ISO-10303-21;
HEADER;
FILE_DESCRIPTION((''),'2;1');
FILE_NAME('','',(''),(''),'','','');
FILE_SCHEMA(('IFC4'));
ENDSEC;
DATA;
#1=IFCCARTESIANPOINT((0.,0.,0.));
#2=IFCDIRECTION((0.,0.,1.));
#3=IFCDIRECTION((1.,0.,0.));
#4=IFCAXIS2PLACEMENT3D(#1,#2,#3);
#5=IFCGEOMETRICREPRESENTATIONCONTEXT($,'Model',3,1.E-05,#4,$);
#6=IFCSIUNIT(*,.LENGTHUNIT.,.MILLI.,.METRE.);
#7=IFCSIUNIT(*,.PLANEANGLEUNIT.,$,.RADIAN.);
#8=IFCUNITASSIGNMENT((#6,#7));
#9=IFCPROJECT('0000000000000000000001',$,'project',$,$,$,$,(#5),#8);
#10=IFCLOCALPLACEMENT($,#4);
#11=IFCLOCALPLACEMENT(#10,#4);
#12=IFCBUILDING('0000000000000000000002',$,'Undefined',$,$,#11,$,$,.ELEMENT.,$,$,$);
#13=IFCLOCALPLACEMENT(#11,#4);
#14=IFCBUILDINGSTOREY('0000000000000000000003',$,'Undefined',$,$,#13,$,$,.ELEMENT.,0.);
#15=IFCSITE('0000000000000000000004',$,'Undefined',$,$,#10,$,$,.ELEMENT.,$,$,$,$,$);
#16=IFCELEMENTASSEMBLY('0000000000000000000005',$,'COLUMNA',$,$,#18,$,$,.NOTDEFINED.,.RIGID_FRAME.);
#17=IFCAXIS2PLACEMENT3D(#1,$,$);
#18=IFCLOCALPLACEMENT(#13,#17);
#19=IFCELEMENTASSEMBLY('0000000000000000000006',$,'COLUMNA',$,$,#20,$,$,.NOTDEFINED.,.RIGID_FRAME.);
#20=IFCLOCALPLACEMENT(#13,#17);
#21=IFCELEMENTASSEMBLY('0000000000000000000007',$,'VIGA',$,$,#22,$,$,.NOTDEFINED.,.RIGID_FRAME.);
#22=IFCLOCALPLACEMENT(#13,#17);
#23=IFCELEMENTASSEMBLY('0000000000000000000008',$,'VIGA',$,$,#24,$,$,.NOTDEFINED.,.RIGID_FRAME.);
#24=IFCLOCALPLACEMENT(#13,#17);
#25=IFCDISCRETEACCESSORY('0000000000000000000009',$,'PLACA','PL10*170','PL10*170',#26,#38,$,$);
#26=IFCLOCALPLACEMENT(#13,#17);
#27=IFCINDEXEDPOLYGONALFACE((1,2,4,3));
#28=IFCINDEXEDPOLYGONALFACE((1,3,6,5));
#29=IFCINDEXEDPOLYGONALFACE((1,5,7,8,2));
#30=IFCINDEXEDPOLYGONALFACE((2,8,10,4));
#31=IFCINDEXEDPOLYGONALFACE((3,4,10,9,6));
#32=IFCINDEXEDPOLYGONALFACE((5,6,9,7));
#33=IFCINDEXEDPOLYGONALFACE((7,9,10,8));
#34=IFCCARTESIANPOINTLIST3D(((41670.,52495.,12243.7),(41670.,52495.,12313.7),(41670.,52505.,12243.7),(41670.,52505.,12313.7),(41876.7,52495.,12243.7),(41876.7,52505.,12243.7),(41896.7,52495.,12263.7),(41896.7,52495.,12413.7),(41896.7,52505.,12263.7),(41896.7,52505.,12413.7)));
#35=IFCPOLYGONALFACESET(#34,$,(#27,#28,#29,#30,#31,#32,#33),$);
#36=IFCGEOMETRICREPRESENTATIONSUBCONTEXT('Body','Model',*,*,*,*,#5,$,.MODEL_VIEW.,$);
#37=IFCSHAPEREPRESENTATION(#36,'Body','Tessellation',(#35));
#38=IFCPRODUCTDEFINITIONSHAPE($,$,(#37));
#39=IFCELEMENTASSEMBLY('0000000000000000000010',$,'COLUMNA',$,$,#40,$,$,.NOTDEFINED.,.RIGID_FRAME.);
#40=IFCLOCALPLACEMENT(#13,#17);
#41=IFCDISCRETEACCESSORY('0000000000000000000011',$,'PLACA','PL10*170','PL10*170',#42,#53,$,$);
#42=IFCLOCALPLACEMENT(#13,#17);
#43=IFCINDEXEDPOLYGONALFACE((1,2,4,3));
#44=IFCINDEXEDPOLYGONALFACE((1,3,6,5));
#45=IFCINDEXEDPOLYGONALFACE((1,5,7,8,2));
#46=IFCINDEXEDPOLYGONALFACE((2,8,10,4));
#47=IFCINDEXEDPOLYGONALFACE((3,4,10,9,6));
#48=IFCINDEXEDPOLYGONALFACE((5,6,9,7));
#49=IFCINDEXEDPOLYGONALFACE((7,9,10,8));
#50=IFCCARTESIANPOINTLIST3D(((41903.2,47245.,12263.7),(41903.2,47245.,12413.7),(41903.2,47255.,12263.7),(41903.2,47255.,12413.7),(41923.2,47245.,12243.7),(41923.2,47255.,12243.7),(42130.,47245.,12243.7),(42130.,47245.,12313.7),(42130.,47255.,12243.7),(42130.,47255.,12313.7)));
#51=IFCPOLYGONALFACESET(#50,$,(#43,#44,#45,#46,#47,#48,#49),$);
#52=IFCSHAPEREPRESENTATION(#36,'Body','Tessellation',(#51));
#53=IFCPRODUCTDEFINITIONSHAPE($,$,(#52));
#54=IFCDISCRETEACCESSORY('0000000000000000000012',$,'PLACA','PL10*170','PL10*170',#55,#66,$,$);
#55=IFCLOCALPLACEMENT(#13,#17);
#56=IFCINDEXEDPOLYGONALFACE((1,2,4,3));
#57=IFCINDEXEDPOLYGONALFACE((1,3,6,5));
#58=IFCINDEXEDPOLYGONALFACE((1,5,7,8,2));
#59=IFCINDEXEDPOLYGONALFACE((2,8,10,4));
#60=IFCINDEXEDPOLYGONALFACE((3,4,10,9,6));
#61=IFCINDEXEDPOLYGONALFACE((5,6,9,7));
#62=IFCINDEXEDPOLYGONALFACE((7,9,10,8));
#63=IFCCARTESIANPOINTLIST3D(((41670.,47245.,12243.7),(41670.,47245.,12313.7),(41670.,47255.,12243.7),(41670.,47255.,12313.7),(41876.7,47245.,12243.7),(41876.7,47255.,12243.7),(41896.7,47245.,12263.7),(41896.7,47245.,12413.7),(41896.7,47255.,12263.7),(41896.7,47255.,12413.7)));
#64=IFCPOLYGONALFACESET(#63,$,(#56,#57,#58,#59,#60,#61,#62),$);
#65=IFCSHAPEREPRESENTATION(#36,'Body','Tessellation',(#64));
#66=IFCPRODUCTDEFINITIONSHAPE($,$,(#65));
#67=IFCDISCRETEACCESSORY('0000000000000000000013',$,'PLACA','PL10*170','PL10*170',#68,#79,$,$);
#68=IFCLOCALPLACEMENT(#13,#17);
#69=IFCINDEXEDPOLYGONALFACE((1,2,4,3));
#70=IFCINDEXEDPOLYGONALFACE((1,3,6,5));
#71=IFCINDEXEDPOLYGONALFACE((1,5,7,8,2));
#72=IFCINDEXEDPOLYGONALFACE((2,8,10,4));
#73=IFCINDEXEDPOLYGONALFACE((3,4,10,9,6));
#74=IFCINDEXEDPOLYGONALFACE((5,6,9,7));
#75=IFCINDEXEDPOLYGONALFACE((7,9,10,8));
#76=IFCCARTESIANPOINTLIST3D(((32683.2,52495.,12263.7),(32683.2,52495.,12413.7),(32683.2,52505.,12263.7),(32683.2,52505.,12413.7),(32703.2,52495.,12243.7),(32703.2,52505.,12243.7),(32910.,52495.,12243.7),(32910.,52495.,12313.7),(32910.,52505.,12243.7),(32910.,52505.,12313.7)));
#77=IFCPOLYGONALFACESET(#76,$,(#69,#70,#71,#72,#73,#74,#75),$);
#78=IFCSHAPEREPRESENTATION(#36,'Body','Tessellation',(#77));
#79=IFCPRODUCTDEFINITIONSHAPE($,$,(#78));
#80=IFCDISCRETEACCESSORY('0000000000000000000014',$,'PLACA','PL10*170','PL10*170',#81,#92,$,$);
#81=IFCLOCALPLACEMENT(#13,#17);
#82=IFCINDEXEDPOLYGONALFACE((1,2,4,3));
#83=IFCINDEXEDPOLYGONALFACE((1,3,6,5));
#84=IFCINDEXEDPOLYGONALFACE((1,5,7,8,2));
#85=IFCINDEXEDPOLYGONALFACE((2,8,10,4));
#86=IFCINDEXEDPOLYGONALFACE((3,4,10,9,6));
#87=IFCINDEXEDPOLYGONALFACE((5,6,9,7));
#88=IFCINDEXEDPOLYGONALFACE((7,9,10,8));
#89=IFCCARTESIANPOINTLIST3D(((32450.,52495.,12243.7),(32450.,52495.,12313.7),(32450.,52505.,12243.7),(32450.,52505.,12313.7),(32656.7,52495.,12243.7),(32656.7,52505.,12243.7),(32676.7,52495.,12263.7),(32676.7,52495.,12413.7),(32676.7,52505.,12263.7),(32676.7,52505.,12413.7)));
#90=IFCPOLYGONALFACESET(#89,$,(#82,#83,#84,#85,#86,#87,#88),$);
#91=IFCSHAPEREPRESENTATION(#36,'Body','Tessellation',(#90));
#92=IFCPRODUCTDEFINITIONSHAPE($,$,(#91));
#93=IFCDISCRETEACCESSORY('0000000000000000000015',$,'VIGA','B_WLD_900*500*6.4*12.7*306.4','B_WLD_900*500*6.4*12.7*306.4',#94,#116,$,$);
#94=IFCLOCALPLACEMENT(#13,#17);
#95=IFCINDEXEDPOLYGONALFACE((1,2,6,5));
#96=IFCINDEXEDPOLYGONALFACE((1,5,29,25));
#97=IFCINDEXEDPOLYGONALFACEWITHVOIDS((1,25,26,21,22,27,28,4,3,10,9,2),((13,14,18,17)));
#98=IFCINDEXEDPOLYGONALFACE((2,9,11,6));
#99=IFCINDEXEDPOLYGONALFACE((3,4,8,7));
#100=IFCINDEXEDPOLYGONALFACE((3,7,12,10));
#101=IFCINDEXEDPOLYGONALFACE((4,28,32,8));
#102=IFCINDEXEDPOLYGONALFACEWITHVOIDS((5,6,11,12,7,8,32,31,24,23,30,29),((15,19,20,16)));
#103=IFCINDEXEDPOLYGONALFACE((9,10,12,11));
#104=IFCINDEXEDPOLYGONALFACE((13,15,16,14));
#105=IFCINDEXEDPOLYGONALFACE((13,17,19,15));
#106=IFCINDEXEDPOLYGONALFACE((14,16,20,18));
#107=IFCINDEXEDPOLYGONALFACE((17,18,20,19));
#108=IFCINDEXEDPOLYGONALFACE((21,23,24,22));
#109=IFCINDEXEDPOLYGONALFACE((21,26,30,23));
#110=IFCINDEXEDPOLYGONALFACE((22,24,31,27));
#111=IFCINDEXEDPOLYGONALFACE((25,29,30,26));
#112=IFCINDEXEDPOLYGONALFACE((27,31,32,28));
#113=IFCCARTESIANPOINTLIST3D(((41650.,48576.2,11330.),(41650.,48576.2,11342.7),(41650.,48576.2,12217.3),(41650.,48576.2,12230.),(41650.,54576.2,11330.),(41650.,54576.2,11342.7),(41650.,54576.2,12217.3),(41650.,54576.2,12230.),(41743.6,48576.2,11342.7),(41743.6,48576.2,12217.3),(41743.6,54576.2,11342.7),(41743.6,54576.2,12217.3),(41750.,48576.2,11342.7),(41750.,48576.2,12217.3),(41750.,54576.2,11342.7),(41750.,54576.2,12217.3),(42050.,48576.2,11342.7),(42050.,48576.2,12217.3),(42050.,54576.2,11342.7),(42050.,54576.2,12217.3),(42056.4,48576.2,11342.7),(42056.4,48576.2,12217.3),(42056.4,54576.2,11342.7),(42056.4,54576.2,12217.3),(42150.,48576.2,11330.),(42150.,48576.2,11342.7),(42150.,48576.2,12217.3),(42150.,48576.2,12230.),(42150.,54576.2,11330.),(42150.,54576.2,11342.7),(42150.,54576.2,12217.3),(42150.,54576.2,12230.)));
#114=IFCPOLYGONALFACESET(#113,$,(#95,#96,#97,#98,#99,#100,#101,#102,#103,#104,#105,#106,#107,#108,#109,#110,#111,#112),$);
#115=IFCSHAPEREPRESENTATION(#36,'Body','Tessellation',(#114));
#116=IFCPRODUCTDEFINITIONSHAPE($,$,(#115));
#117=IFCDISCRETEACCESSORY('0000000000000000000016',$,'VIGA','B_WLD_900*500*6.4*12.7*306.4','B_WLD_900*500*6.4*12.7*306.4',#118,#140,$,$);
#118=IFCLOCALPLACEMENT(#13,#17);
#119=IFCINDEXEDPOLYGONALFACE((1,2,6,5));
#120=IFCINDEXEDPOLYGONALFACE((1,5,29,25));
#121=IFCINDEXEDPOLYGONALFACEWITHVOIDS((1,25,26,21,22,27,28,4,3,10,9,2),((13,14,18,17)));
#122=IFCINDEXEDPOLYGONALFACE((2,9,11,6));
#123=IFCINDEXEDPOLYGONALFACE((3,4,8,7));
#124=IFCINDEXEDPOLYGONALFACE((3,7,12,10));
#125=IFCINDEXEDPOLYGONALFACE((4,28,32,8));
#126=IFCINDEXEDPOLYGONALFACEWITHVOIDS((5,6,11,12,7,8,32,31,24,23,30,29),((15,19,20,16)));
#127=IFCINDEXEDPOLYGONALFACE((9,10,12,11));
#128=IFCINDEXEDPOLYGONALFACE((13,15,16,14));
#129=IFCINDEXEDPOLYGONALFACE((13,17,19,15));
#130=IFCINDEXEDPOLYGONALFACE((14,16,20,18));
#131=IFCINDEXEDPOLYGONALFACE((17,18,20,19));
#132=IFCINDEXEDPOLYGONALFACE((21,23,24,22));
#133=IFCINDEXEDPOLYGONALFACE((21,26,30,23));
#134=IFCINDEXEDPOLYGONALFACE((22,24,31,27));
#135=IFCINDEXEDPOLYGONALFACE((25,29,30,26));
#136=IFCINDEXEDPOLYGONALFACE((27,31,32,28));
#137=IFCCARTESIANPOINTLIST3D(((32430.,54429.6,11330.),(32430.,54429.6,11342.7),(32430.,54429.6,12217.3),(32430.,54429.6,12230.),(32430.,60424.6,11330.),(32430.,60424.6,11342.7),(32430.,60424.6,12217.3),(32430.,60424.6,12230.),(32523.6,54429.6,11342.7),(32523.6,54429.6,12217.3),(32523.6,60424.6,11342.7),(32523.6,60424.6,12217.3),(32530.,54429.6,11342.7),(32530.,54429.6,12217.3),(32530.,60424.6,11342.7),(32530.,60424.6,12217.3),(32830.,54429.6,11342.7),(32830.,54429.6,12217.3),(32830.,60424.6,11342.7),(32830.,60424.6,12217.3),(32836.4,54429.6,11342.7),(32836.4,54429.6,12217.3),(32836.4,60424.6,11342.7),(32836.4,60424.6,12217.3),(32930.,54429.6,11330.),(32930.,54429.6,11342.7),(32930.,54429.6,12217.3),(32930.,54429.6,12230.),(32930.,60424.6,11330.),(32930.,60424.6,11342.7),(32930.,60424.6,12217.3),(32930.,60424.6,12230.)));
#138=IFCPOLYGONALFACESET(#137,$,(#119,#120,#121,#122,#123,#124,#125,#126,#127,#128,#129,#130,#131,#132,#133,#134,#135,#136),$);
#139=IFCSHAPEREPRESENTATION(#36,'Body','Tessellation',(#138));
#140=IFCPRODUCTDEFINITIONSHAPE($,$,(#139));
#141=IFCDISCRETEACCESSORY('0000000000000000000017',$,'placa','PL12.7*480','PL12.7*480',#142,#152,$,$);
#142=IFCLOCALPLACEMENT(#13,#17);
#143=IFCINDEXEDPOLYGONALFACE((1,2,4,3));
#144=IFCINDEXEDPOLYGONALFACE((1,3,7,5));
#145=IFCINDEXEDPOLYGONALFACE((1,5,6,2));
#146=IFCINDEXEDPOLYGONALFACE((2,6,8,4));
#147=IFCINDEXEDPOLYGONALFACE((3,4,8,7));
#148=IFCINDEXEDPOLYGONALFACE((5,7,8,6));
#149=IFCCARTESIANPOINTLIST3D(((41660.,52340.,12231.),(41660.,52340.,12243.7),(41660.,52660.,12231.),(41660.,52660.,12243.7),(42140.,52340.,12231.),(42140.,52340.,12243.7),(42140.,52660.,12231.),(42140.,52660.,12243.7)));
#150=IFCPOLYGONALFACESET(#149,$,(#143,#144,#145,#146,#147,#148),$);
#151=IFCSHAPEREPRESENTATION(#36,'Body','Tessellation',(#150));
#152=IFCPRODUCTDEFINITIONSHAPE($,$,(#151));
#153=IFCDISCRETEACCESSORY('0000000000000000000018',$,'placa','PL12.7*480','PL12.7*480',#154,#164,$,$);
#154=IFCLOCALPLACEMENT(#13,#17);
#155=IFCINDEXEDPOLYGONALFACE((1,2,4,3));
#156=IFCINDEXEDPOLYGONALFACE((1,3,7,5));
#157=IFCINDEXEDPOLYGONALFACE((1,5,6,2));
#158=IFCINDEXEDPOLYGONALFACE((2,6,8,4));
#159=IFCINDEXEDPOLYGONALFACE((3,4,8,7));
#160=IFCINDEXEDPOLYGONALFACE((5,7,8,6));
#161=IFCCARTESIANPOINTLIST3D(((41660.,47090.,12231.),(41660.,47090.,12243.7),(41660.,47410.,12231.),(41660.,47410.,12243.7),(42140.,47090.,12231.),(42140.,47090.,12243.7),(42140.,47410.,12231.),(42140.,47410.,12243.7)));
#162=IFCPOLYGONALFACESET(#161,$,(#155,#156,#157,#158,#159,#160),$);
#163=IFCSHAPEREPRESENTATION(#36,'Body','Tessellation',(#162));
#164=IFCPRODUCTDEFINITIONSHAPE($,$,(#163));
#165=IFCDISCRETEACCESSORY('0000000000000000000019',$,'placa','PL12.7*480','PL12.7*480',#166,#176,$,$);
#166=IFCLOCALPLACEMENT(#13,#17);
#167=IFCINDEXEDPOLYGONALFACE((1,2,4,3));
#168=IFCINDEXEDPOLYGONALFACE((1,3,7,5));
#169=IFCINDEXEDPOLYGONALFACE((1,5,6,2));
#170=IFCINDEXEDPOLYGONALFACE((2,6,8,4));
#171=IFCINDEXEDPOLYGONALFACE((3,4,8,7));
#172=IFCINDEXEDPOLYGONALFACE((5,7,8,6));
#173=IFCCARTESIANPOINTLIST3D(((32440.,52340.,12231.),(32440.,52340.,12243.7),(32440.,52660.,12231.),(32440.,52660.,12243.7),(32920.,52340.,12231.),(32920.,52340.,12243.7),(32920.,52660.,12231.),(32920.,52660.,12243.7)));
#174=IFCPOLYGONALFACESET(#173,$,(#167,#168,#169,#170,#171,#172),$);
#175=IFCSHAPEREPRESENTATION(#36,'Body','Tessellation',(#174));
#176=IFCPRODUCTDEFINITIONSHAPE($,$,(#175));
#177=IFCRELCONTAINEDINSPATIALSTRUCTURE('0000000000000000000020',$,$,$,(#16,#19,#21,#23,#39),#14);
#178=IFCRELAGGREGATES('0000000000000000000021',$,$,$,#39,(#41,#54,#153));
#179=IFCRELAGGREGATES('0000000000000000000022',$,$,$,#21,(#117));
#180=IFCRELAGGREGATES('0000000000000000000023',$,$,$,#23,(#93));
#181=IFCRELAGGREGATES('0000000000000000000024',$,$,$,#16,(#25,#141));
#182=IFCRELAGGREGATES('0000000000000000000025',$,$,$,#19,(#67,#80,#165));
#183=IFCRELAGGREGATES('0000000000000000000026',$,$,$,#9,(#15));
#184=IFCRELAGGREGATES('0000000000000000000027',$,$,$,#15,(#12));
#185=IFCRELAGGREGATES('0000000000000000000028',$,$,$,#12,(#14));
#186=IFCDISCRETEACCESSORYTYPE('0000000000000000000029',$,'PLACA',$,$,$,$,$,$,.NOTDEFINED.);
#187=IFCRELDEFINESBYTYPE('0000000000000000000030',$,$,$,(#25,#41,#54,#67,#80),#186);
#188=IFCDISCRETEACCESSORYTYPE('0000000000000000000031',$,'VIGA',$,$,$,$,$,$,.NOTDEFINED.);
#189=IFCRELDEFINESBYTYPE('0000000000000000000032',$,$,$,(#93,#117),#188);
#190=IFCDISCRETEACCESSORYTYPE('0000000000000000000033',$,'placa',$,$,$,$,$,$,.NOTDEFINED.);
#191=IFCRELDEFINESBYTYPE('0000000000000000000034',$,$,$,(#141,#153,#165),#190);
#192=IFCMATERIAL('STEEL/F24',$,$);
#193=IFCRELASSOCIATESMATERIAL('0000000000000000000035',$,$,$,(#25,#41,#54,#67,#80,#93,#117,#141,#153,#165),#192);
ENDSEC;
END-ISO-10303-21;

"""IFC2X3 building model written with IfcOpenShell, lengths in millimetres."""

from ifc_helpers import new_model, si_unit, frame, origin_with_axes, place, context, subcontext, project, spatial, polyline, outline, extrude, clip, halfspace, material, type_object, element, aggregate, save


model = new_model("IFC2X3")

# Units and contexts
model_context = context("Model", 3, precision=1e-05, world=origin_with_axes())
body_context = subcontext(model_context, "Body", "Model", "MODEL_VIEW")
ifc_project = project(units=[si_unit("LENGTHUNIT", "METRE", prefix="MILLI"), si_unit("PLANEANGLEUNIT", "RADIAN")], contexts=[model_context])

# Site, building, storey
site_placement = place(None, origin_with_axes())
site = spatial("IfcSite", under=ifc_project, at=site_placement, Name="Undefined", CompositionType="ELEMENT")
building_placement = place(site_placement, origin_with_axes())
building = spatial("IfcBuilding", under=site, at=building_placement, Name="Undefined", CompositionType="ELEMENT")
storey_placement = place(building_placement, origin_with_axes())
storey = spatial("IfcBuildingStorey", under=building, at=storey_placement, Name="Undefined", CompositionType="ELEMENT", Elevation=0.0)

# Element assemblies
assembly_1_placement = place(storey_placement, origin_with_axes())
assembly_1 = element("IfcElementAssembly", 1, at=assembly_1_placement, inside=storey, Name="COLUMNA", AssemblyPlace="NOTDEFINED", PredefinedType="RIGID_FRAME")
ifc_material_1 = material(Name="STEEL/F24")
assembly_2_placement = place(storey_placement, origin_with_axes())
assembly_2 = element("IfcElementAssembly", 2, at=assembly_2_placement, inside=storey, Name="COLUMNA", AssemblyPlace="NOTDEFINED", PredefinedType="RIGID_FRAME")

# Element assemblies
assembly_3_placement = place(storey_placement, origin_with_axes())
assembly_3 = element("IfcElementAssembly", 3, at=assembly_3_placement, inside=storey, Name="VIGA", AssemblyPlace="NOTDEFINED", PredefinedType="RIGID_FRAME")
assembly_4_placement = place(storey_placement, origin_with_axes())
assembly_4 = element("IfcElementAssembly", 4, at=assembly_4_placement, inside=storey, Name="VIGA", AssemblyPlace="NOTDEFINED", PredefinedType="RIGID_FRAME")

# Discrete accessory
discrete_accessory_type_1 = type_object("IfcDiscreteAccessoryType", Name="PLACA")
discrete_accessory_1_placement = place(assembly_1_placement, frame((41896.7, 52500.0, 12243.7), z_axis=(0.0, -1.0, 0.0), x_axis=(0.0, 0.0, 1.0)))
discrete_accessory_1 = element("IfcDiscreteAccessory", 5, at=discrete_accessory_1_placement, type_object=discrete_accessory_type_1, material=ifc_material_1, Name="PLACA", Description="PL10*170", ObjectType="PL10*170", context=body_context, shape_type="SweptSolid", body=[
    extrude(outline(polyline([(0.0, 20.0), (20.0, 0.0), (170.0, 0.0), (70.0, 226.7), (0.0, 226.7), (0.0, 20.0)])), frame((0.0, 0.0, -5.0), z_axis=(0.0, 0.0, 1.0), x_axis=(1.0, 0.0, 0.0)), (0.0, 0.0, 1.0), 10.0),
])

# Element assembly, discrete accessories
assembly_5_placement = place(storey_placement, origin_with_axes())
assembly_5 = element("IfcElementAssembly", 6, at=assembly_5_placement, inside=storey, Name="COLUMNA", AssemblyPlace="NOTDEFINED", PredefinedType="RIGID_FRAME")
discrete_accessory_2_placement = place(assembly_5_placement, frame((41903.2, 47250.0, 12243.7), z_axis=(0.0, 1.0, 0.0), x_axis=(0.0, 0.0, 1.0)))
discrete_accessory_2 = element("IfcDiscreteAccessory", 7, at=discrete_accessory_2_placement, type_object=discrete_accessory_type_1, material=ifc_material_1, Name="PLACA", Description="PL10*170", ObjectType="PL10*170", context=body_context, shape_type="SweptSolid", body=[
    extrude(outline(polyline([(0.0, 20.0), (20.0, 0.0), (170.0, 0.0), (70.0, 226.7), (0.0, 226.7), (0.0, 20.0)])), frame((0.0, 0.0, -5.0), z_axis=(0.0, 0.0, 1.0), x_axis=(1.0, 0.0, 0.0)), (0.0, 0.0, 1.0), 10.0),
])
discrete_accessory_3_placement = place(assembly_5_placement, frame((41896.7, 47250.0, 12243.7), z_axis=(0.0, -1.0, 0.0), x_axis=(0.0, 0.0, 1.0)))
discrete_accessory_3 = element("IfcDiscreteAccessory", 8, at=discrete_accessory_3_placement, type_object=discrete_accessory_type_1, material=ifc_material_1, Name="PLACA", Description="PL10*170", ObjectType="PL10*170", context=body_context, shape_type="SweptSolid", body=[
    extrude(outline(polyline([(0.0, 20.0), (20.0, 0.0), (170.0, 0.0), (70.0, 226.7), (0.0, 226.7), (0.0, 20.0)])), frame((0.0, 0.0, -5.0), z_axis=(0.0, 0.0, 1.0), x_axis=(1.0, 0.0, 0.0)), (0.0, 0.0, 1.0), 10.0),
])

# Discrete accessories
discrete_accessory_4_placement = place(assembly_2_placement, frame((32683.2, 52500.0, 12243.7), z_axis=(0.0, 1.0, 0.0), x_axis=(0.0, 0.0, 1.0)))
discrete_accessory_4 = element("IfcDiscreteAccessory", 9, at=discrete_accessory_4_placement, type_object=discrete_accessory_type_1, material=ifc_material_1, Name="PLACA", Description="PL10*170", ObjectType="PL10*170", context=body_context, shape_type="SweptSolid", body=[
    extrude(outline(polyline([(0.0, 20.0), (20.0, 0.0), (170.0, 0.0), (70.0, 226.7), (0.0, 226.7), (0.0, 20.0)])), frame((0.0, 0.0, -5.0), z_axis=(0.0, 0.0, 1.0), x_axis=(1.0, 0.0, 0.0)), (0.0, 0.0, 1.0), 10.0),
])
discrete_accessory_5_placement = place(assembly_2_placement, frame((32676.7, 52500.0, 12243.7), z_axis=(0.0, -1.0, 0.0), x_axis=(0.0, 0.0, 1.0)))
discrete_accessory_5 = element("IfcDiscreteAccessory", 10, at=discrete_accessory_5_placement, type_object=discrete_accessory_type_1, material=ifc_material_1, Name="PLACA", Description="PL10*170", ObjectType="PL10*170", context=body_context, shape_type="SweptSolid", body=[
    extrude(outline(polyline([(0.0, 20.0), (20.0, 0.0), (170.0, 0.0), (70.0, 226.7), (0.0, 226.7), (0.0, 20.0)])), frame((0.0, 0.0, -5.0), z_axis=(0.0, 0.0, 1.0), x_axis=(1.0, 0.0, 0.0)), (0.0, 0.0, 1.0), 10.0),
])
discrete_accessory_type_2 = type_object("IfcDiscreteAccessoryType", Name="VIGA")
discrete_accessory_6_placement = place(assembly_4_placement, frame((41900.0, 48576.2, 11780.0), z_axis=(0.0, 0.0, 1.0), x_axis=(0.0, 1.0, 0.0)))
discrete_accessory_6 = element("IfcDiscreteAccessory", 11, at=discrete_accessory_6_placement, type_object=discrete_accessory_type_2, material=ifc_material_1, Name="VIGA", Description="B_WLD_900*500*6.4*12.7*306.4", ObjectType="B_WLD_900*500*6.4*12.7*306.4", context=body_context, shape_type="SweptSolid", body=[
    extrude(outline(polyline([(-250.0, 437.3), (-250.0, 450.0), (250.0, 450.0), (250.0, 437.3), (156.4, 437.3), (156.4, -437.3), (250.0, -437.3), (250.0, -450.0), (-250.0, -450.0), (-250.0, -437.3), (-156.4, -437.3), (-156.4, 437.3), (-250.0, 437.3)]), holes=[polyline([(-150.0, -437.3), (150.0, -437.3), (150.0, 437.3), (-150.0, 437.3), (-150.0, -437.3)])]), frame((6000.0, 0.0, 0.0), z_axis=(-1.0, 0.0, 0.0), x_axis=(0.0, -1.0, 0.0)), (0.0, 0.0, 1.0), 6000.0),
])
discrete_accessory_7_placement = place(assembly_3_placement, frame((32680.0, 54424.6, 11780.0), z_axis=(0.0, 0.0, 1.0), x_axis=(0.0, 1.0, 0.0)))
discrete_accessory_7 = element("IfcDiscreteAccessory", 12, at=discrete_accessory_7_placement, type_object=discrete_accessory_type_2, material=ifc_material_1, Name="VIGA", Description="B_WLD_900*500*6.4*12.7*306.4", ObjectType="B_WLD_900*500*6.4*12.7*306.4", context=body_context, shape_type="Clipping", body=[
    clip(extrude(outline(polyline([(-250.0, 437.3), (-250.0, 450.0), (250.0, 450.0), (250.0, 437.3), (156.4, 437.3), (156.4, -437.3), (250.0, -437.3), (250.0, -450.0), (-250.0, -450.0), (-250.0, -437.3), (-156.4, -437.3), (-156.4, 437.3), (-250.0, 437.3)]), holes=[polyline([(-150.0, -437.3), (150.0, -437.3), (150.0, 437.3), (-150.0, 437.3), (-150.0, -437.3)])]), frame((6000.0, 0.0, 0.0), z_axis=(-1.0, 0.0, 0.0), x_axis=(0.0, -1.0, 0.0)), (0.0, 0.0, 1.0), 6000.0), halfspace(frame((5.0, -175.0, 450.0), z_axis=(-1.0, -0.000001, 0.0), x_axis=(0.0, 0.0, -1.0)), False)),
])
discrete_accessory_type_3 = type_object("IfcDiscreteAccessoryType", Name="placa")
discrete_accessory_8_placement = place(assembly_1_placement, frame((41900.0, 52660.0, 12237.4), z_axis=(0.0, 0.0, 1.0), x_axis=(0.0, -1.0, 0.0)))
discrete_accessory_8 = element("IfcDiscreteAccessory", 13, at=discrete_accessory_8_placement, type_object=discrete_accessory_type_3, material=ifc_material_1, Name="placa", Description="PL12.7*480", ObjectType="PL12.7*480", context=body_context, shape_type="SweptSolid", body=[
    extrude(outline(polyline([(320.0, -240.0), (0.0, -240.0), (0.0, 240.0), (320.0, 240.0), (320.0, -240.0)])), frame((0.0, 0.0, -6.3), z_axis=(0.0, 0.0, 1.0), x_axis=(1.0, 0.0, 0.0)), (0.0, 0.0, 1.0), 12.7),
])
discrete_accessory_9_placement = place(assembly_5_placement, frame((41900.0, 47410.0, 12237.4), z_axis=(0.0, 0.0, 1.0), x_axis=(0.0, -1.0, 0.0)))
discrete_accessory_9 = element("IfcDiscreteAccessory", 14, at=discrete_accessory_9_placement, type_object=discrete_accessory_type_3, material=ifc_material_1, Name="placa", Description="PL12.7*480", ObjectType="PL12.7*480", context=body_context, shape_type="SweptSolid", body=[
    extrude(outline(polyline([(320.0, -240.0), (0.0, -240.0), (0.0, 240.0), (320.0, 240.0), (320.0, -240.0)])), frame((0.0, 0.0, -6.3), z_axis=(0.0, 0.0, 1.0), x_axis=(1.0, 0.0, 0.0)), (0.0, 0.0, 1.0), 12.7),
])
aggregate(assembly_5, [discrete_accessory_2, discrete_accessory_3, discrete_accessory_9])
discrete_accessory_10_placement = place(assembly_2_placement, frame((32680.0, 52660.0, 12237.4), z_axis=(0.0, 0.0, 1.0), x_axis=(0.0, -1.0, 0.0)))
discrete_accessory_10 = element("IfcDiscreteAccessory", 15, at=discrete_accessory_10_placement, type_object=discrete_accessory_type_3, material=ifc_material_1, Name="placa", Description="PL12.7*480", ObjectType="PL12.7*480", context=body_context, shape_type="SweptSolid", body=[
    extrude(outline(polyline([(320.0, -240.0), (0.0, -240.0), (0.0, 240.0), (320.0, 240.0), (320.0, -240.0)])), frame((0.0, 0.0, -6.3), z_axis=(0.0, 0.0, 1.0), x_axis=(1.0, 0.0, 0.0)), (0.0, 0.0, 1.0), 12.7),
])

aggregate(assembly_3, [discrete_accessory_7])
aggregate(assembly_4, [discrete_accessory_6])
aggregate(assembly_1, [discrete_accessory_1, discrete_accessory_8])
aggregate(assembly_2, [discrete_accessory_4, discrete_accessory_5, discrete_accessory_10])

save(model, "model.ifc")
